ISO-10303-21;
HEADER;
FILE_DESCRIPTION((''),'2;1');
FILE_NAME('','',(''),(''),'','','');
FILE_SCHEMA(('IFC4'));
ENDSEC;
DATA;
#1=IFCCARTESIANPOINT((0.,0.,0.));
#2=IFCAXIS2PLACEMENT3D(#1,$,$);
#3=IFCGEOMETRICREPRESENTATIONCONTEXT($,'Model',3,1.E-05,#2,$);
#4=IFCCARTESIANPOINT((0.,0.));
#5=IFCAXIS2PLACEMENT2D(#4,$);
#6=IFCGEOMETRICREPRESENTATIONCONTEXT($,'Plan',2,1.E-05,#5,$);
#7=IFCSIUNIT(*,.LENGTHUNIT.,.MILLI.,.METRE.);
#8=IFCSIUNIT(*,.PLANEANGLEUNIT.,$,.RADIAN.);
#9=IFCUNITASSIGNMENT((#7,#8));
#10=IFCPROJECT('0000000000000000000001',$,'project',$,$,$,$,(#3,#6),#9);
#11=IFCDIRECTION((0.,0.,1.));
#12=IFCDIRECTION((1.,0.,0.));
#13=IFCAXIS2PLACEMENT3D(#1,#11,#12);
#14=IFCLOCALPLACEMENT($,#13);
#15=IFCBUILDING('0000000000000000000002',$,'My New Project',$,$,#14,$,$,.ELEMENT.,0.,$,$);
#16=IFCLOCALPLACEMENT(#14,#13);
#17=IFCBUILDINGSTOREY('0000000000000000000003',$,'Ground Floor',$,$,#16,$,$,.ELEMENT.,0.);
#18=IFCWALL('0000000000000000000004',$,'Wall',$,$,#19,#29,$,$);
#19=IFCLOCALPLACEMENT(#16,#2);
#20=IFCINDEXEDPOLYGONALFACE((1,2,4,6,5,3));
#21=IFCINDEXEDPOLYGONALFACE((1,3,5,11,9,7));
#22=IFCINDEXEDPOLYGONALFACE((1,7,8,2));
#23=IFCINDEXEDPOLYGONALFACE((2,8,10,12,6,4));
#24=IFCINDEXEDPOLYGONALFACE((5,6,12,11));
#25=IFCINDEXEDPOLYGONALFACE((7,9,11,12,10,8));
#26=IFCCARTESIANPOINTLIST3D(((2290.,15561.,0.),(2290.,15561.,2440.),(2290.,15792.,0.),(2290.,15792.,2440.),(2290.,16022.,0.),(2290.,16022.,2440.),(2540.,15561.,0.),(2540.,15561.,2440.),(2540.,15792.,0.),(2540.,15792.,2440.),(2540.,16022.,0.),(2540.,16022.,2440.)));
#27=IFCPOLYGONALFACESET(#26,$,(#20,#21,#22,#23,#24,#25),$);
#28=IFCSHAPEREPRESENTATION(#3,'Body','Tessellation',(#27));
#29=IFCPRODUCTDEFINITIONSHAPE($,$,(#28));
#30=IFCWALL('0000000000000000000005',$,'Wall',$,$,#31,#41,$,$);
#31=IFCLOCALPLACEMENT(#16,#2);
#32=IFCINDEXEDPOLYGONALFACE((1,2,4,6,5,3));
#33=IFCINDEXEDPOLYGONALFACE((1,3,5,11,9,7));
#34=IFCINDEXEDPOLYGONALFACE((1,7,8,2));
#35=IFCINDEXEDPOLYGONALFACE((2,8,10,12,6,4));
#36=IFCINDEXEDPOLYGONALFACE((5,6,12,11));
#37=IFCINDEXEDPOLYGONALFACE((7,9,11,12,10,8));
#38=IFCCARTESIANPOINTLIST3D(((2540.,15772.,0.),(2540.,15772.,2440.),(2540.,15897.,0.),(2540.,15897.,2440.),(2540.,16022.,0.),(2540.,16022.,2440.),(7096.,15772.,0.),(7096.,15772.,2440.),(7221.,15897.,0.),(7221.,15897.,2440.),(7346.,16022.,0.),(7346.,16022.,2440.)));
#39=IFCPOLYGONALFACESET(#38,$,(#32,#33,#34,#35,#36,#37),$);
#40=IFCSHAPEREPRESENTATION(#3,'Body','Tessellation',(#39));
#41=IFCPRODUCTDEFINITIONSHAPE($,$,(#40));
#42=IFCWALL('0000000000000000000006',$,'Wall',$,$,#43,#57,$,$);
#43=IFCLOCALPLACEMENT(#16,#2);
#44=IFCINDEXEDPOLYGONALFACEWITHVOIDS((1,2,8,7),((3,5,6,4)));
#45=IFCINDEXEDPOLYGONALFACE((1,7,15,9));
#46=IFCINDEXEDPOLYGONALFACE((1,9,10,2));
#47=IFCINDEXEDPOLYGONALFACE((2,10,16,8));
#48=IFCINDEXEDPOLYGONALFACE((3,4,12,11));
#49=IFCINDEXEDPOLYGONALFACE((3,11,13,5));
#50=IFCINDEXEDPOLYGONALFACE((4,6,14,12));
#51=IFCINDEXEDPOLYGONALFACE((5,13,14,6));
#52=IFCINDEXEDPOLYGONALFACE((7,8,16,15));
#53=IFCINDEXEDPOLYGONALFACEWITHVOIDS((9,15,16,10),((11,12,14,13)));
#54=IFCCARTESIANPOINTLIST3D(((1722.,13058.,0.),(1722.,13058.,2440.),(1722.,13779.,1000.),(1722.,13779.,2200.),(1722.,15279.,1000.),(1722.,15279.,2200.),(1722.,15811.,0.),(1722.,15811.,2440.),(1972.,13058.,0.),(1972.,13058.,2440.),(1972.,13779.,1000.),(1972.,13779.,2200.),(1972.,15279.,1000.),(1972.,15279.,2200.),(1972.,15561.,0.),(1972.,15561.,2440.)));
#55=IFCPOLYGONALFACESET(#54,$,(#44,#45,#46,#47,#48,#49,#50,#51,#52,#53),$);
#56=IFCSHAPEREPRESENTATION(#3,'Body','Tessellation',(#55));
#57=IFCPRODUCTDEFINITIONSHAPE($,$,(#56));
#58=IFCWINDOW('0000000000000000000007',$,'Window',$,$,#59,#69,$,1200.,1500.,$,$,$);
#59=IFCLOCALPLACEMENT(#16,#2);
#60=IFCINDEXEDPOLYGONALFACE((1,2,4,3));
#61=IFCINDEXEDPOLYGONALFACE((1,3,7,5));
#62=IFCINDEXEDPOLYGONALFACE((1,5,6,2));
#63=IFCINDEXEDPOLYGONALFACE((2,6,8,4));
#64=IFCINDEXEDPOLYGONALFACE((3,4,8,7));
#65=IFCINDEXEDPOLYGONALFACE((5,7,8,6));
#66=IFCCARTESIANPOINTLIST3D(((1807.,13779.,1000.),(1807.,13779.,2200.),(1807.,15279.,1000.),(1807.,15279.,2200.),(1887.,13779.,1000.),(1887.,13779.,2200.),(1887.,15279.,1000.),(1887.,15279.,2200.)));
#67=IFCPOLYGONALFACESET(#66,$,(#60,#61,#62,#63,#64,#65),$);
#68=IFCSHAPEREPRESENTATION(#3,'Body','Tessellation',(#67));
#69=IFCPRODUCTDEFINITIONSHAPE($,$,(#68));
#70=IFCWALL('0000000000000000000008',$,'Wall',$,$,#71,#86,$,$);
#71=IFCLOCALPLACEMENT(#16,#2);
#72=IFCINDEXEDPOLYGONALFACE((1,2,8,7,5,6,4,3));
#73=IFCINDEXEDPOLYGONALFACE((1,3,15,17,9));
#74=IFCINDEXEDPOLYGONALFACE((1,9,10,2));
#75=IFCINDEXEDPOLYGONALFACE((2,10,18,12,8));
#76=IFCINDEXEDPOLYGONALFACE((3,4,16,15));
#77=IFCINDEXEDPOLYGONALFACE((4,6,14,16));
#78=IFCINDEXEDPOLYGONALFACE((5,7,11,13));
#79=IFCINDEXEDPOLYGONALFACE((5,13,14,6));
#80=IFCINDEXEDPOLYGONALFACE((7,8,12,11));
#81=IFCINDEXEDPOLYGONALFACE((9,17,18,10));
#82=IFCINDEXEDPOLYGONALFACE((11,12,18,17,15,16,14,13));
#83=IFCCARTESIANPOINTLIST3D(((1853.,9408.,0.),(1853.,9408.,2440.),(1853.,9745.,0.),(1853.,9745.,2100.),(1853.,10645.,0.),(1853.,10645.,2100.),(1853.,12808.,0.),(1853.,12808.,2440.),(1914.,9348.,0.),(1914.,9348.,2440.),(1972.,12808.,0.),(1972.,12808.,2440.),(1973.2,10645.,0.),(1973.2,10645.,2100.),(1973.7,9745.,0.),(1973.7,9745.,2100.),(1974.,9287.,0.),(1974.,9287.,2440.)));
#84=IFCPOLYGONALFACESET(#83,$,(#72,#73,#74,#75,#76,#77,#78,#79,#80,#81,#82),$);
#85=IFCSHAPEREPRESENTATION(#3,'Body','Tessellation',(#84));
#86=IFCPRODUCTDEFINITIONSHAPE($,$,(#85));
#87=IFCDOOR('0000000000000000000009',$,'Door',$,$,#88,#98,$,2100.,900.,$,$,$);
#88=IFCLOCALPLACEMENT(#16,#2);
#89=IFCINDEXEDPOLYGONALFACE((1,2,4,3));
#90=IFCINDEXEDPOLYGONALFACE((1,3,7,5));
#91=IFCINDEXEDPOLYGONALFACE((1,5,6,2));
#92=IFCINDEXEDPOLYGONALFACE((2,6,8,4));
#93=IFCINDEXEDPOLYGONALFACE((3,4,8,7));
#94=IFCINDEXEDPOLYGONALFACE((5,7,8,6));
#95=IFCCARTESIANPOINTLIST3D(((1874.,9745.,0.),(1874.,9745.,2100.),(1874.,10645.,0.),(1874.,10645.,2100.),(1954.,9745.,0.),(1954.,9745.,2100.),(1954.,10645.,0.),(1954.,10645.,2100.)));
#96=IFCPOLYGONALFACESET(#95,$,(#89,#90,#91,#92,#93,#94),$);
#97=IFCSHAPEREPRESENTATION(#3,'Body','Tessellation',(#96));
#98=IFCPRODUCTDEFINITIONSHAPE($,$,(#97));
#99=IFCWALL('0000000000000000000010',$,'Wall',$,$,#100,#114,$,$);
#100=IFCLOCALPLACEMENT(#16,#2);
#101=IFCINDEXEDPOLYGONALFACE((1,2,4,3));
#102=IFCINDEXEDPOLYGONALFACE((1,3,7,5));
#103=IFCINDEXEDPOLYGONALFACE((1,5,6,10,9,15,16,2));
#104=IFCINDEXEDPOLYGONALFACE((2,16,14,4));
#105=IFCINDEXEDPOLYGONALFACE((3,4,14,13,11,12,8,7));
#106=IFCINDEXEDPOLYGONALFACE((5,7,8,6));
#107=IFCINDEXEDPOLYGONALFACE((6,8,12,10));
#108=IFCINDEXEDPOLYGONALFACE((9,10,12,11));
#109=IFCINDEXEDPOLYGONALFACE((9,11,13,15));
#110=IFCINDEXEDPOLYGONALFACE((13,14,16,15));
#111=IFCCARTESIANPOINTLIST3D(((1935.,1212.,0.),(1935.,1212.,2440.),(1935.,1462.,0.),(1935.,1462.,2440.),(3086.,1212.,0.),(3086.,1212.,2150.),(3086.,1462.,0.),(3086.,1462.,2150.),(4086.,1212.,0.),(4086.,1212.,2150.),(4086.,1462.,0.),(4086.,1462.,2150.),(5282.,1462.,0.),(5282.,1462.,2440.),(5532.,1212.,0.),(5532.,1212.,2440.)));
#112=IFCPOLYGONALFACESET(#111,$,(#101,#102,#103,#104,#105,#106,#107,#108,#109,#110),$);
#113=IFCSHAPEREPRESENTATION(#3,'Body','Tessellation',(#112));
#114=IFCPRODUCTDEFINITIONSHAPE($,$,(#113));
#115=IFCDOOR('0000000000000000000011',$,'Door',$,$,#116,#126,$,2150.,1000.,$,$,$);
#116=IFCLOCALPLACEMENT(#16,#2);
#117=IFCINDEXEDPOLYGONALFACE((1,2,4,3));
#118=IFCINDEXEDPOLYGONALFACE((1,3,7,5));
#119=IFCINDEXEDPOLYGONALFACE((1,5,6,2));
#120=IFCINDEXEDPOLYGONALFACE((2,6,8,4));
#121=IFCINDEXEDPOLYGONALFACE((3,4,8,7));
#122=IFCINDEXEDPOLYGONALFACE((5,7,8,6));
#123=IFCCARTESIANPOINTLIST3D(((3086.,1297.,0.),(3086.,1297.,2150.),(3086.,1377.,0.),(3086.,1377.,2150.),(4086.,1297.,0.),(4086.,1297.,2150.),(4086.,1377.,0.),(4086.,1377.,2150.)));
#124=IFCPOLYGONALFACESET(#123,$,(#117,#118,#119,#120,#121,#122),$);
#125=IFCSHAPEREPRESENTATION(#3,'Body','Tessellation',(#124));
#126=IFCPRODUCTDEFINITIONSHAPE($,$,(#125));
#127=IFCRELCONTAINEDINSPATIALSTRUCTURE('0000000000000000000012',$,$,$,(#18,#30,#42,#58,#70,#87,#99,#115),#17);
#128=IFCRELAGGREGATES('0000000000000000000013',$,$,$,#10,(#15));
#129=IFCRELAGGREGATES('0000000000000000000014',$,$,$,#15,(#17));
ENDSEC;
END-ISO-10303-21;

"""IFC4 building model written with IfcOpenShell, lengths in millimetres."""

from ifc_helpers import new_model, si_unit, frame, origin, origin_with_axes, origin_2d, origin_2d_with_axis, place, context, project, spatial, polyline, rectangle, outline, extrude, element, fill, save


model = new_model("IFC4")

# Units and contexts
model_context = context("Model", 3, precision=1e-05, world=origin())
plan_context = context("Plan", 2, precision=1e-05, world=origin_2d())
ifc_project = project(units=[si_unit("LENGTHUNIT", "METRE", prefix="MILLI"), si_unit("PLANEANGLEUNIT", "RADIAN")], contexts=[model_context, plan_context])

# Building, storey
building_placement = place(None, origin_with_axes())
building = spatial("IfcBuilding", under=ifc_project, at=building_placement, Name="My New Project", CompositionType="ELEMENT", ElevationOfRefHeight=0.0)
storey_placement = place(building_placement, origin_with_axes())
storey = spatial("IfcBuildingStorey", under=building, at=storey_placement, Name="Ground Floor", CompositionType="ELEMENT", Elevation=0.0)

# Walls
wall_1_placement = place(storey_placement, origin_with_axes())
element("IfcWall", 1, at=wall_1_placement, inside=storey, Name="Wall", context=model_context, shape_type="SweptSolid", body=[
    extrude(outline(polyline([(2540.0, 15792.0, 0.0), (2540.0, 15561.0, 0.0), (2290.0, 15561.0, 0.0), (2290.0, 15792.0, 0.0), (2290.0, 16022.0, 0.0), (2540.0, 16022.0, 0.0), (2540.0, 15792.0, 0.0)])), origin_with_axes(), (0.0, 0.0, 1.0), 2440.0),
])
wall_2_placement = place(storey_placement, origin_with_axes())
element("IfcWall", 2, at=wall_2_placement, inside=storey, Name="Wall", context=model_context, shape_type="SweptSolid", body=[
    extrude(outline(polyline([(7221.0, 15897.0, 0.0), (7096.0, 15772.0, 0.0), (2540.0, 15772.0, 0.0), (2540.0, 15897.0, 0.0), (2540.0, 16022.0, 0.0), (7346.0, 16022.0, 0.0), (7221.0, 15897.0, 0.0)])), origin_with_axes(), (0.0, 0.0, 1.0), 2440.0),
])

# Wall, opening, window
wall_3_placement = place(storey_placement, origin_with_axes())
wall_3 = element("IfcWall", 3, at=wall_3_placement, inside=storey, Name="Wall", context=model_context, shape_type="SweptSolid", body=[
    extrude(outline(polyline([(1847.0, 13058.0, 0.0), (1722.0, 13058.0, 0.0), (1722.0, 15811.0, 0.0), (1847.0, 15686.0, 0.0), (1972.0, 15561.0, 0.0), (1972.0, 13058.0, 0.0), (1847.0, 13058.0, 0.0)])), origin_with_axes(), (0.0, 0.0, 1.0), 2440.0),
])
opening_1_placement = place(wall_3_placement, frame((1622.0, 14529.0, 1600.0), z_axis=(0.0, 0.0, 1.0), x_axis=(1.0, 0.0, 0.0)))
opening_1 = element("IfcOpeningElement", 4, at=opening_1_placement, cuts=wall_3, PredefinedType="OPENING", context=model_context, shape_type="SweptSolid", body=[
    extrude(rectangle(XDim=1500.0, YDim=1200.0, at=origin_2d_with_axis()), frame((0.0, 0.0, 0.0), z_axis=(2753.0, 0.0, 0.0), x_axis=(0.0, 2753.0, 0.0)), (0.0, 0.0, 1.0), 450.0),
])
window_1_placement = place(opening_1_placement, frame((185.0, 0.0, 0.0), z_axis=(0.0, 0.0, 1.0), x_axis=(1.0, 0.0, 0.0)))
window_1 = element("IfcWindow", 5, at=window_1_placement, inside=storey, Name="Window", OverallHeight=1200.0, OverallWidth=1500.0, context=model_context, shape_type="SweptSolid", body=[
    extrude(outline(polyline([(750.0, 600.0, 0.0), (750.0, -600.0, 0.0), (-750.0, -600.0, 0.0), (-750.0, 600.0, 0.0), (750.0, 600.0, 0.0)])), frame((0.0, 0.0, 0.0), z_axis=(2753.0, 0.0, 0.0), x_axis=(0.0, 2753.0, 0.0)), (0.0, 0.0, 1.0), 80.0),
])
fill(opening_1, window_1)

# Walls, openings, doors
wall_4_placement = place(storey_placement, origin_with_axes())
wall_4 = element("IfcWall", 6, at=wall_4_placement, inside=storey, Name="Wall", context=model_context, shape_type="SweptSolid", body=[
    extrude(outline(polyline([(1914.0, 9348.0, 0.0), (1853.0, 9408.0, 0.0), (1853.0, 12808.0, 0.0), (1913.0, 12808.0, 0.0), (1972.0, 12808.0, 0.0), (1974.0, 9287.0, 0.0), (1914.0, 9348.0, 0.0)])), origin_with_axes(), (0.0, 0.0, 1.0), 2440.0),
])
opening_2_placement = place(wall_4_placement, frame((1753.0, 10195.0, 1050.0), z_axis=(0.0, 0.0, 1.0), x_axis=(1.0, 0.0, 0.0)))
opening_2 = element("IfcOpeningElement", 7, at=opening_2_placement, cuts=wall_4, PredefinedType="OPENING", context=model_context, shape_type="SweptSolid", body=[
    extrude(rectangle(XDim=900.0, YDim=2100.0, at=origin_2d_with_axis()), frame((0.0, 0.0, 0.0), z_axis=(3400.0, 0.0, 0.0), x_axis=(0.0, 3400.0, 0.0)), (0.0, 0.0, 1.0), 321.0),
])
door_1_placement = place(opening_2_placement, frame((121.0, 0.0, 0.0), z_axis=(0.0, 0.0, 1.0), x_axis=(1.0, 0.0, 0.0)))
door_1 = element("IfcDoor", 8, at=door_1_placement, inside=storey, Name="Door", OverallHeight=2100.0, OverallWidth=900.0, context=model_context, shape_type="SweptSolid", body=[
    extrude(outline(polyline([(450.0, 1050.0, 0.0), (450.0, -1050.0, 0.0), (-450.0, -1050.0, 0.0), (-450.0, 1050.0, 0.0), (450.0, 1050.0, 0.0)])), frame((0.0, 0.0, 0.0), z_axis=(3400.0, 0.0, 0.0), x_axis=(0.0, 3400.0, 0.0)), (0.0, 0.0, 1.0), 80.0),
])
fill(opening_2, door_1)
wall_5_placement = place(storey_placement, origin_with_axes())
wall_5 = element("IfcWall", 9, at=wall_5_placement, inside=storey, Name="Wall", context=model_context, shape_type="SweptSolid", body=[
    extrude(outline(polyline([(1935.0, 1337.0, 0.0), (1935.0, 1462.0, 0.0), (5282.0, 1462.0, 0.0), (5407.0, 1337.0, 0.0), (5532.0, 1212.0, 0.0), (1935.0, 1212.0, 0.0), (1935.0, 1337.0, 0.0)])), origin_with_axes(), (0.0, 0.0, 1.0), 2440.0),
])
opening_3_placement = place(wall_5_placement, frame((3586.0, 1562.0, 1075.0), z_axis=(0.0, 0.0, 1.0), x_axis=(1.0, 0.0, 0.0)))
opening_3 = element("IfcOpeningElement", 10, at=opening_3_placement, cuts=wall_5, PredefinedType="OPENING", context=model_context, shape_type="SweptSolid", body=[
    extrude(rectangle(XDim=1000.0, YDim=2150.0, at=origin_2d_with_axis()), frame((0.0, 0.0, 0.0), z_axis=(0.0, -3347.0, 0.0), x_axis=(3347.0, 0.0, 0.0)), (0.0, 0.0, 1.0), 450.0),
])
door_2_placement = place(opening_3_placement, frame((0.0, -185.0, 0.0), z_axis=(0.0, 0.0, 1.0), x_axis=(1.0, 0.0, 0.0)))
door_2 = element("IfcDoor", 11, at=door_2_placement, inside=storey, Name="Door", OverallHeight=2150.0, OverallWidth=1000.0, context=model_context, shape_type="SweptSolid", body=[
    extrude(outline(polyline([(500.0, 1075.0, 0.0), (500.0, -1075.0, 0.0), (-500.0, -1075.0, 0.0), (-500.0, 1075.0, 0.0), (500.0, 1075.0, 0.0)])), frame((0.0, 0.0, 0.0), z_axis=(0.0, -3347.0, 0.0), x_axis=(3347.0, 0.0, 0.0)), (0.0, 0.0, 1.0), 80.0),
])
fill(opening_3, door_2)

save(model, "model.ifc")
